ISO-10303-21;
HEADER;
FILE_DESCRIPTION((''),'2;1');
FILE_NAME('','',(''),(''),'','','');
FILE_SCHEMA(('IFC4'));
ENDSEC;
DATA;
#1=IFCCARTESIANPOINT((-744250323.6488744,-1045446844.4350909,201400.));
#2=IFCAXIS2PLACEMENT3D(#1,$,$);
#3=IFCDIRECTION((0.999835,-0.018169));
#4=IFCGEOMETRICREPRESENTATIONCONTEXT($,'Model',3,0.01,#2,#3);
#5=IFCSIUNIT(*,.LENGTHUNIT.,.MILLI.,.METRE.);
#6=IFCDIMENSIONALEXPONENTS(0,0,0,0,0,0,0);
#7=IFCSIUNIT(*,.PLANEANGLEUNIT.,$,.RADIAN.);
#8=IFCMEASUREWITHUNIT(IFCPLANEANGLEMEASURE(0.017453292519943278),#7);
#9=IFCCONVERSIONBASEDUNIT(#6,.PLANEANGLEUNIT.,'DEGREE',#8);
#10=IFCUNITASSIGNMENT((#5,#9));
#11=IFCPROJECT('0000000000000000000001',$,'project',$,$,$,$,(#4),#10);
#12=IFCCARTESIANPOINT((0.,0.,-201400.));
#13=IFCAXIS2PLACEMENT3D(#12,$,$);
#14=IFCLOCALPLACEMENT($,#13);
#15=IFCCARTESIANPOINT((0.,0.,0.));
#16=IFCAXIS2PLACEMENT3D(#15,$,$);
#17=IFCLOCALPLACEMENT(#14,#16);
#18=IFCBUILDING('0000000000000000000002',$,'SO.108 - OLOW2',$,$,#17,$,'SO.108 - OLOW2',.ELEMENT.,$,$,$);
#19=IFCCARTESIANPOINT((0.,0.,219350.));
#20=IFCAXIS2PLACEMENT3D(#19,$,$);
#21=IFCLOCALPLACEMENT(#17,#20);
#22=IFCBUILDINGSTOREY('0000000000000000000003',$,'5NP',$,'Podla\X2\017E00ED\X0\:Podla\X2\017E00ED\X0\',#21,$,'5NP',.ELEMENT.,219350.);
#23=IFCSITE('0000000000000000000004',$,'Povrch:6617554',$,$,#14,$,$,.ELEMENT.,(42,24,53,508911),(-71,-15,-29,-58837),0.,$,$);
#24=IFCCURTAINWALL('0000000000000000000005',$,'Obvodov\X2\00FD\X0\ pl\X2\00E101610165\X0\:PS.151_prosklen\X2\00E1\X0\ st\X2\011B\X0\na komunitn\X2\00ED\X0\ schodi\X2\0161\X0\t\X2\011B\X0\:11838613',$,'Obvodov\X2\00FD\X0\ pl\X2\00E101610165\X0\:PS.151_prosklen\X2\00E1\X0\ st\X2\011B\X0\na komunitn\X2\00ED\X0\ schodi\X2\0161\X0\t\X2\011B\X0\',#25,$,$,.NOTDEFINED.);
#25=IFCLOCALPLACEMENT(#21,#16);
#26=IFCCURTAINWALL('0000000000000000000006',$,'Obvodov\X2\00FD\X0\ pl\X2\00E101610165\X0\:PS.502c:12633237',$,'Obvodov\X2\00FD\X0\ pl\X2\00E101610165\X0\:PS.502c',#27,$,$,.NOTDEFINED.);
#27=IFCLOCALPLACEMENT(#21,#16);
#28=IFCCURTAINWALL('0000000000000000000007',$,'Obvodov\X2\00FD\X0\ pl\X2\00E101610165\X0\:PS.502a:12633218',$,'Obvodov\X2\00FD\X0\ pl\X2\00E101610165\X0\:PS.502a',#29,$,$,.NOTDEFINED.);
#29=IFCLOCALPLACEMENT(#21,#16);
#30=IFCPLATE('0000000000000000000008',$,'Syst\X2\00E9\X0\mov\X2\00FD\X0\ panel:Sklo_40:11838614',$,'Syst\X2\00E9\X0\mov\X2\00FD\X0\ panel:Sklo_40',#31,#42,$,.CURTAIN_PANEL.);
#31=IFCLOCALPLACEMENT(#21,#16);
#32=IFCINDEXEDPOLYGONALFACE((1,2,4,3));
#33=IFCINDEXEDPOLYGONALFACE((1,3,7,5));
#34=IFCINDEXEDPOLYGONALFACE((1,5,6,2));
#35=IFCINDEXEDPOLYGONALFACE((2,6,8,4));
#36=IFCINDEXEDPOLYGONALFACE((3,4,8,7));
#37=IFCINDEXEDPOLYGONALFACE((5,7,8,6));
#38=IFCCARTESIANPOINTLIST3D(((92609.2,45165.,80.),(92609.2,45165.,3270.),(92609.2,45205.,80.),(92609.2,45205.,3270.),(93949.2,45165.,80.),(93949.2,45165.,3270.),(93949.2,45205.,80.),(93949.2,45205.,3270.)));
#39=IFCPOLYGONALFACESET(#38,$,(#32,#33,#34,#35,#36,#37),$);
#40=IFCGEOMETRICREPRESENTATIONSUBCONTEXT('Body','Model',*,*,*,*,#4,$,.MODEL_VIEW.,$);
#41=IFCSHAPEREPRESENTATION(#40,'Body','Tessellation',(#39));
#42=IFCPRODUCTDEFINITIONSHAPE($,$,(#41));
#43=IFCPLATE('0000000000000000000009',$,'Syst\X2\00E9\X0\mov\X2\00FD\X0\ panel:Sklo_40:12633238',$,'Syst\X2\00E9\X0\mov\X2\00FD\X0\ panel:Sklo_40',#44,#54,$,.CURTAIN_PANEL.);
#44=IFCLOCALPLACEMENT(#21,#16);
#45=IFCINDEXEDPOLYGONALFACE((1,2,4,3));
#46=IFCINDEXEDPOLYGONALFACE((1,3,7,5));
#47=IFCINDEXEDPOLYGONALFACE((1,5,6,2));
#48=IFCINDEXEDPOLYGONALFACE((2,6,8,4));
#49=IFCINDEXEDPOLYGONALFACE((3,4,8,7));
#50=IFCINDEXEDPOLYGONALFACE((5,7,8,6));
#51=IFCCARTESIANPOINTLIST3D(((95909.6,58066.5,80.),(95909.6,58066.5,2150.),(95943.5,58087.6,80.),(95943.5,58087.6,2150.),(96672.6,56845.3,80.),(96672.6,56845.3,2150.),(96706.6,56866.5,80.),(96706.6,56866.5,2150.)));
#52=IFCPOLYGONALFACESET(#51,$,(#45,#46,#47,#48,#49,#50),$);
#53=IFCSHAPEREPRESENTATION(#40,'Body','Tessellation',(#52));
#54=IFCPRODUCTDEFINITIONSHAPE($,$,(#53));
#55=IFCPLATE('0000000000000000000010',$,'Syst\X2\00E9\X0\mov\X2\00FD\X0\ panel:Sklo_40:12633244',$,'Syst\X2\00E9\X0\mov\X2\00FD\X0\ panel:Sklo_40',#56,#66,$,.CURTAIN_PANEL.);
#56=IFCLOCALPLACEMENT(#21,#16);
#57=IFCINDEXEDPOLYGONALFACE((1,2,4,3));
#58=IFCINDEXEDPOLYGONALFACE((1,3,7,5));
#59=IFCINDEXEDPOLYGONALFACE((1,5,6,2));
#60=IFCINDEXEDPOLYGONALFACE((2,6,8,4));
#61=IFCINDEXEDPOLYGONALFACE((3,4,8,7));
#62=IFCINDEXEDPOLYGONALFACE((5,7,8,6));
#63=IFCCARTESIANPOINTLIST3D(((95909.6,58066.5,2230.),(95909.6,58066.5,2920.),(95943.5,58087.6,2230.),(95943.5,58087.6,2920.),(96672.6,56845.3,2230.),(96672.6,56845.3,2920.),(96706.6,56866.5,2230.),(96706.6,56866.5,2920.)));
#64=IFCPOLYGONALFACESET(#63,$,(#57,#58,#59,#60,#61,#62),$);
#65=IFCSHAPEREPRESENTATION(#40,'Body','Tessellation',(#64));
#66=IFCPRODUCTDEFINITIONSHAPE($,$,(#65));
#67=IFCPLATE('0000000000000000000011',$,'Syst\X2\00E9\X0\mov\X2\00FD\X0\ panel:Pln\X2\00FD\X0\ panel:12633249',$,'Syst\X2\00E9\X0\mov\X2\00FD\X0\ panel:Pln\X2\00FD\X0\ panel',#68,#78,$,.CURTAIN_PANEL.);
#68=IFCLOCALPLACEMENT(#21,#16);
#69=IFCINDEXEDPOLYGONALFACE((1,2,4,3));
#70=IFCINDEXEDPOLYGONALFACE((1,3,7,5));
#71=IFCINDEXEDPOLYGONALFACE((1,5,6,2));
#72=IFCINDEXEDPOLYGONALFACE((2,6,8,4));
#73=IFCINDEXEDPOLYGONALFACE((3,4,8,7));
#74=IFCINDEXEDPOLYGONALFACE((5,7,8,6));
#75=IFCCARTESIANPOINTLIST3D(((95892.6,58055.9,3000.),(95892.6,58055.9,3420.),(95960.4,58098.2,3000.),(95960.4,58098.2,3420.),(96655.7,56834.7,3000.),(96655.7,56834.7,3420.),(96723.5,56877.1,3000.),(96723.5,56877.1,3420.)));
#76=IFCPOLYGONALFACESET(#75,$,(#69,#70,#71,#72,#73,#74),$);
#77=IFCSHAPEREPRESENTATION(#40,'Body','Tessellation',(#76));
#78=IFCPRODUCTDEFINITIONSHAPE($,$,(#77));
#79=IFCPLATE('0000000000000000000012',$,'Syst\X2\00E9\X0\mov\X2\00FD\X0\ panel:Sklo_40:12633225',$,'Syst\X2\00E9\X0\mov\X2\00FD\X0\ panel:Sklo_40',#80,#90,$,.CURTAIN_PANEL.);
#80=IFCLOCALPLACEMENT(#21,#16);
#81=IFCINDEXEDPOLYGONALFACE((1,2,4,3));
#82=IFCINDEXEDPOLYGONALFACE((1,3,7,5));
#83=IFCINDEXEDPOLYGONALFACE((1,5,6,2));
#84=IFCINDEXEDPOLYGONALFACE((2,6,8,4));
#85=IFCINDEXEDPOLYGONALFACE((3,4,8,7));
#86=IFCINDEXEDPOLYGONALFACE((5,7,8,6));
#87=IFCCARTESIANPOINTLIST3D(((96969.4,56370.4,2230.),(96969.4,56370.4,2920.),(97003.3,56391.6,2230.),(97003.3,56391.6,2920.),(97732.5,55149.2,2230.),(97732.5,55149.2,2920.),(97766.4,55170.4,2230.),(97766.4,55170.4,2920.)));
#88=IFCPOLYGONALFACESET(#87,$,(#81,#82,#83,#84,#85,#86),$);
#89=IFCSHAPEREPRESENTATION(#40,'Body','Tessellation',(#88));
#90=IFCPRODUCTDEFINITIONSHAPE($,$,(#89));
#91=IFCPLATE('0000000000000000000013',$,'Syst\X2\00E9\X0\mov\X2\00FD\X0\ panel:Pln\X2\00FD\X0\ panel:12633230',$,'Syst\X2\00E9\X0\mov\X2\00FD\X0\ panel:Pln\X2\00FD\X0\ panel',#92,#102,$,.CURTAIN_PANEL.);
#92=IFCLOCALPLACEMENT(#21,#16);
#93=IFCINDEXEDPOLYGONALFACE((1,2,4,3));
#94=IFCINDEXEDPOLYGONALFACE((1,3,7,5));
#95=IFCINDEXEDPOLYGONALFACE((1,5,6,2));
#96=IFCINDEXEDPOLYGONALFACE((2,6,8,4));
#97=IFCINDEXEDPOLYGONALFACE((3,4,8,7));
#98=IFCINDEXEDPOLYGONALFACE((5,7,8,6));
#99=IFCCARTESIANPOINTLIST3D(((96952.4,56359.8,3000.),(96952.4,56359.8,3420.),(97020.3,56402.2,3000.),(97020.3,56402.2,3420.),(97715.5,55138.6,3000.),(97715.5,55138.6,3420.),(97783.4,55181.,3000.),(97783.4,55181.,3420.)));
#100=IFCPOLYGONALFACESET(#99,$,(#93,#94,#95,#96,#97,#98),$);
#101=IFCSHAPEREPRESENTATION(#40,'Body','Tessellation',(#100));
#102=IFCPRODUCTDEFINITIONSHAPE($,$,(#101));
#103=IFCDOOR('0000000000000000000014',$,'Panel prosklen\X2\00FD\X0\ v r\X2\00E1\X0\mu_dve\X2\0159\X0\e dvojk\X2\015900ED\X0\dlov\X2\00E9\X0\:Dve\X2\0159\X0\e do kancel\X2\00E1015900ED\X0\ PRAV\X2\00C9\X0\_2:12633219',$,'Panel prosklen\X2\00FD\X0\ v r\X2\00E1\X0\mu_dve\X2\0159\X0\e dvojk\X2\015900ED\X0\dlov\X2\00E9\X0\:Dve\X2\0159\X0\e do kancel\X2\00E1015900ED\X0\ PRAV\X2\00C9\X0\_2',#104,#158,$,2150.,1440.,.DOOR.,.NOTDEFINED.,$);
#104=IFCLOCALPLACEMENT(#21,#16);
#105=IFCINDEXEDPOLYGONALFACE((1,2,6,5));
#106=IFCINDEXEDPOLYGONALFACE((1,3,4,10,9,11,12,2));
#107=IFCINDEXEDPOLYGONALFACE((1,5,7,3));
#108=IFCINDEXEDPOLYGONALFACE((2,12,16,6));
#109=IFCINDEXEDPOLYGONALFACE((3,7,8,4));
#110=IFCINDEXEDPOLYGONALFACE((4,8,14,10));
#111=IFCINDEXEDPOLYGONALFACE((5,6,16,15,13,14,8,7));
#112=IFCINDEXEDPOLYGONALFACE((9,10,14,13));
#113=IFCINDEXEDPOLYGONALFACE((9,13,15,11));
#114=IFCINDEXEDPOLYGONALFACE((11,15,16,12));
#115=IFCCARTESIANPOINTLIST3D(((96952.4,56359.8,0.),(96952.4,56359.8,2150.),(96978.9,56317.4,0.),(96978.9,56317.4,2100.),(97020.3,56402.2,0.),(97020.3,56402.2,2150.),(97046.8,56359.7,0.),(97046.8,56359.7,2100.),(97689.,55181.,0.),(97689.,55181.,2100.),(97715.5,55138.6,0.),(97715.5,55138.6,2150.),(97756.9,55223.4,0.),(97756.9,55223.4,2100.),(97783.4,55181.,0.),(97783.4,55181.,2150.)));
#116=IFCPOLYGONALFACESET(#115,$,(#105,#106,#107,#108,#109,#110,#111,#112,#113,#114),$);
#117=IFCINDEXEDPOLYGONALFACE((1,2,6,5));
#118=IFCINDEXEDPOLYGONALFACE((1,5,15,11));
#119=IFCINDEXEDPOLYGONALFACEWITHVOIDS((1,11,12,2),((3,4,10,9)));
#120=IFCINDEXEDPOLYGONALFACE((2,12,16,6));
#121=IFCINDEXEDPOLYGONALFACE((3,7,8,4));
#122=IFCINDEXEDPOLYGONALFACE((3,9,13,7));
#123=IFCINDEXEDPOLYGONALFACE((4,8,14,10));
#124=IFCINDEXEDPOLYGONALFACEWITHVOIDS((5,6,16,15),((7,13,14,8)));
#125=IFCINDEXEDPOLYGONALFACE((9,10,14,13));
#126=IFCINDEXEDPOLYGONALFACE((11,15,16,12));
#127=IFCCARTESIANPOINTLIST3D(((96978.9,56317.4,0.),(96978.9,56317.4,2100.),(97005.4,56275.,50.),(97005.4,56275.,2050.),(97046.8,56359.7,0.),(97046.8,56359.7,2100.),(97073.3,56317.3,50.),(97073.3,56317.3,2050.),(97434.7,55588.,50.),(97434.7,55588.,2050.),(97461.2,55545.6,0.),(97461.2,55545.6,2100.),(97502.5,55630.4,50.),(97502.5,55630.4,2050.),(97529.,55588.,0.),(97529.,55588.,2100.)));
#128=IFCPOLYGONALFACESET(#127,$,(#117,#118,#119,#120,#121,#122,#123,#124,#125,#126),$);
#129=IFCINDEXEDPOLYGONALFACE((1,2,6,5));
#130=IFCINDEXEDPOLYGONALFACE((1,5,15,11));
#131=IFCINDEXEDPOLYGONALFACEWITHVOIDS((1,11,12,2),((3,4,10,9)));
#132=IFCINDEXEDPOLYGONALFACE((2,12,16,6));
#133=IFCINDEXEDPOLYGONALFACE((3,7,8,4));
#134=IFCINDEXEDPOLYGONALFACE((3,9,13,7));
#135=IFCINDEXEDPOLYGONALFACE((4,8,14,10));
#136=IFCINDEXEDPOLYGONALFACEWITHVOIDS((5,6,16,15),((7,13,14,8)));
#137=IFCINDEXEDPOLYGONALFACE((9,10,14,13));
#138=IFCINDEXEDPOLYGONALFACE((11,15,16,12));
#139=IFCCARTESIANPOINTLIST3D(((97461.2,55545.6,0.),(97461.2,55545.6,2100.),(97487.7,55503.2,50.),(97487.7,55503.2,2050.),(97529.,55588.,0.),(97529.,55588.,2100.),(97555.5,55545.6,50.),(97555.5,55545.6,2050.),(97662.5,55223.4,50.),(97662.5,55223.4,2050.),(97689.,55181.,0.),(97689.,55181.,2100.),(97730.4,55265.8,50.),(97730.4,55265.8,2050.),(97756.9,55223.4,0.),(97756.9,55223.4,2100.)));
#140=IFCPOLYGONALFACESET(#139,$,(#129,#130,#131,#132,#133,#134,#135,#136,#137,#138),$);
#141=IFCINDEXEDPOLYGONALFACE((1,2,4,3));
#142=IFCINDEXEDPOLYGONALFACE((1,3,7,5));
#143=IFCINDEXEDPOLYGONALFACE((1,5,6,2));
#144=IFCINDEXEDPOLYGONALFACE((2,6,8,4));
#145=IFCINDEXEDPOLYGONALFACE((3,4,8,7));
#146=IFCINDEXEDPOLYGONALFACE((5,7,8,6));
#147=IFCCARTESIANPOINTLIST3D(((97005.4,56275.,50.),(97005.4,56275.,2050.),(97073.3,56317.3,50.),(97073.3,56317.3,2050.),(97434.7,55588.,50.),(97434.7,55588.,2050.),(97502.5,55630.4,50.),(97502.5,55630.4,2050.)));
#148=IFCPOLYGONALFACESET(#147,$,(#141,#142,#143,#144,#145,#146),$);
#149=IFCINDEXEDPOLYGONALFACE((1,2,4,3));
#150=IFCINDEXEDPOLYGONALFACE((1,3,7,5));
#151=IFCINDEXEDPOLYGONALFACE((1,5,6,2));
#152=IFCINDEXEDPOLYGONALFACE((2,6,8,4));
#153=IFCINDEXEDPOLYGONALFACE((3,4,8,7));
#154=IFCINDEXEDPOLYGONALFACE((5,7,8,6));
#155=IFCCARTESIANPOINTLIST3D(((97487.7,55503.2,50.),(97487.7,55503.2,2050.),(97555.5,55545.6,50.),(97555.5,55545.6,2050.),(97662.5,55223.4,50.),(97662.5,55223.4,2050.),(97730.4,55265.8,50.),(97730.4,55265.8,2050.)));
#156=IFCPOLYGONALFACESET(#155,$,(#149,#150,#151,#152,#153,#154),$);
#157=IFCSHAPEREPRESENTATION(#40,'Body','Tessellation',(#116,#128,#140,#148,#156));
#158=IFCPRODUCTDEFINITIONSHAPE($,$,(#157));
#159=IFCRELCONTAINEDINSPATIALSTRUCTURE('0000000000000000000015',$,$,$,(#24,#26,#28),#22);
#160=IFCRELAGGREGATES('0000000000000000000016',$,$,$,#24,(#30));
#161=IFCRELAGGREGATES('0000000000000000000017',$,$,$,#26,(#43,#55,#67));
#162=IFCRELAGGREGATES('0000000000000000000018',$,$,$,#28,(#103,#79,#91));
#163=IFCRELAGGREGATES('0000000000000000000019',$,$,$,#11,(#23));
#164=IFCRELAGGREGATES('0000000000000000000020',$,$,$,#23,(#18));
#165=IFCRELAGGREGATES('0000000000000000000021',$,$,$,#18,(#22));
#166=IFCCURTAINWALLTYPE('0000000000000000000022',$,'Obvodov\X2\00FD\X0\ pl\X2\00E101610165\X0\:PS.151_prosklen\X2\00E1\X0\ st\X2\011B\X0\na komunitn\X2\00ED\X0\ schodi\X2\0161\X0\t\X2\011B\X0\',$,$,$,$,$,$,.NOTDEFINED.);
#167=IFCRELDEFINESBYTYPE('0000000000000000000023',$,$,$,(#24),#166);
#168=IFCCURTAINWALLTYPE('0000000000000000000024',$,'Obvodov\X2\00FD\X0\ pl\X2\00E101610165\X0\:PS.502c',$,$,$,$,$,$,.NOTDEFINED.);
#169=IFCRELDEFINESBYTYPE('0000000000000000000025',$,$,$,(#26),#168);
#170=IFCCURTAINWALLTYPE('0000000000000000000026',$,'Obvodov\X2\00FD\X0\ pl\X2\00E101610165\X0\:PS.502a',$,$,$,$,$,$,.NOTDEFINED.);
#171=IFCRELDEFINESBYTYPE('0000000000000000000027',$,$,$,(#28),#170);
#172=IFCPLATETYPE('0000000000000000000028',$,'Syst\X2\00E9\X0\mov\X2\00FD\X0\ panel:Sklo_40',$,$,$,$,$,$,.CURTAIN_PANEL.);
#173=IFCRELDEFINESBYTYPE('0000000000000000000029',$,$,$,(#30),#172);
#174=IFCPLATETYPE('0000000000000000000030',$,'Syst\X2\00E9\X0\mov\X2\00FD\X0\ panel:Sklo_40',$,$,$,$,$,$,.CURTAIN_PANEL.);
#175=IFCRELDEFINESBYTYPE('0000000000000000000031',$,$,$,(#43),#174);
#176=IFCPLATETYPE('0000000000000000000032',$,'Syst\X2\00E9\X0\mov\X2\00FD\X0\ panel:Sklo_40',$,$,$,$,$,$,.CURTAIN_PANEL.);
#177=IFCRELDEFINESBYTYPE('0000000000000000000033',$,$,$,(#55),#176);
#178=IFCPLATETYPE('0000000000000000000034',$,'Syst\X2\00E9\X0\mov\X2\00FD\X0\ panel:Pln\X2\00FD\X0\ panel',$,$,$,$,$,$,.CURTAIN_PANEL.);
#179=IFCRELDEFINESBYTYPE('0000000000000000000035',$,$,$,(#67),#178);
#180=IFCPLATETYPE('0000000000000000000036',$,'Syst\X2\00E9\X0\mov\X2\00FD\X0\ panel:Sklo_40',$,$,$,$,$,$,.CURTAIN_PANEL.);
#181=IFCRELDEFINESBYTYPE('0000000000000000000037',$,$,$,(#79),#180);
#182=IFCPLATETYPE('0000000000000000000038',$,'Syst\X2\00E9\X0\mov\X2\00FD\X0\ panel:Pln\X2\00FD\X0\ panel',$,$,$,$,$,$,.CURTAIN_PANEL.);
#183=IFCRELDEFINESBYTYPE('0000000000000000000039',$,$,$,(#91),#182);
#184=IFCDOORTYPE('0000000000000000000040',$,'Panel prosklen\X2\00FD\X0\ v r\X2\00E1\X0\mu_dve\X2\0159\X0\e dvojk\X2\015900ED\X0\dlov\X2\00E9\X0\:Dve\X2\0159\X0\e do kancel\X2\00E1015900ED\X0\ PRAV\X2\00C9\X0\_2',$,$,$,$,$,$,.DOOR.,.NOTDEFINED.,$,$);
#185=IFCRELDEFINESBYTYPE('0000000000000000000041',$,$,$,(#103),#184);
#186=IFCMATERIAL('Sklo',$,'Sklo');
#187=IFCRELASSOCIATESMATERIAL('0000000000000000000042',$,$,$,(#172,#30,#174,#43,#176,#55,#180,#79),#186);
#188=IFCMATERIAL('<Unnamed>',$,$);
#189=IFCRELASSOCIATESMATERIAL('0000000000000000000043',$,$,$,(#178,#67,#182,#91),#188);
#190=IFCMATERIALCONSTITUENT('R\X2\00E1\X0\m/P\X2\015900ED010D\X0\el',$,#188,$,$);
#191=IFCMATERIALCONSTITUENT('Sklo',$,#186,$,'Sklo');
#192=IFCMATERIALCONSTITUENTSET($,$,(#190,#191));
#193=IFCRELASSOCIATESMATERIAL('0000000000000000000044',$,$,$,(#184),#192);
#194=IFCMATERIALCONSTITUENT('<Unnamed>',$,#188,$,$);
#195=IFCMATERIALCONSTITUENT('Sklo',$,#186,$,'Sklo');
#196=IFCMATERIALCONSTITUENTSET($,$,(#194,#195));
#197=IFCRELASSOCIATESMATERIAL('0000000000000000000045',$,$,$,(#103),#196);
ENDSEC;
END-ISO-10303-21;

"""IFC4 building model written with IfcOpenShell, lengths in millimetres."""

from ifc_helpers import new_model, entity, si_unit, converted_unit, direction, frame, origin, place, context, subcontext, project, spatial, indexed_curve, outline, extrude, source, transform, mapped, material, constituent, constituent_set, type_object, type_shapes, element, aggregate, save


model = new_model("IFC4")

# Units and contexts
model_context = context("Model", 3, precision=0.01, world=frame((-744250323.6488744, -1045446844.4350909, 201400.0)), true_north=direction((0.999835, -0.018169)))
body_context = subcontext(model_context, "Body", "Model", "MODEL_VIEW")
ifc_project = project(units=[si_unit("LENGTHUNIT", "METRE", prefix="MILLI"), converted_unit("PLANEANGLEUNIT", "DEGREE", entity("IfcPlaneAngleMeasure", 0.017453292519943278), si_unit("PLANEANGLEUNIT", "RADIAN"), dimensions=[0, 0, 0, 0, 0, 0, 0])], contexts=[model_context])

# Site, building, storey
site_placement = place(None, frame((0.0, 0.0, -201400.0)))
site = spatial("IfcSite", under=ifc_project, at=site_placement, Name="Povrch:6617554", CompositionType="ELEMENT", RefLatitude=(42, 24, 53, 508911), RefLongitude=(-71, -15, -29, -58837), RefElevation=0.0)
building_placement = place(site_placement, origin())
building = spatial("IfcBuilding", under=site, at=building_placement, Name="SO.108 - OLOW2", LongName="SO.108 - OLOW2", CompositionType="ELEMENT")
storey_placement = place(building_placement, frame((0.0, 0.0, 219350.0)))
storey = spatial("IfcBuildingStorey", under=building, at=storey_placement, Name="5NP", ObjectType="Podlaží:Podlaží", LongName="5NP", CompositionType="ELEMENT", Elevation=219350.0)

# Curtain wall
curtain_wall_type_1 = type_object("IfcCurtainWallType", Name="Obvodový plášť:PS.151_prosklená stěna komunitní schodiště", PredefinedType="NOTDEFINED")
curtain_wall_1_placement = place(storey_placement, frame((0.0, 0.0, -219350.0)))
curtain_wall_1 = element("IfcCurtainWall", 1, at=curtain_wall_1_placement, inside=storey, type_object=curtain_wall_type_1, Name="Obvodový plášť:PS.151_prosklená stěna komunitní schodiště:11838613", ObjectType="Obvodový plášť:PS.151_prosklená stěna komunitní schodiště", PredefinedType="NOTDEFINED")
ifc_material_1 = material(Name="<Unnamed>")

# Curtain wall
curtain_wall_type_2 = type_object("IfcCurtainWallType", Name="Obvodový plášť:PS.502c", PredefinedType="NOTDEFINED")
curtain_wall_2_placement = place(storey_placement, frame((0.0, 0.0, -219350.0)))
curtain_wall_2 = element("IfcCurtainWall", 2, at=curtain_wall_2_placement, inside=storey, type_object=curtain_wall_type_2, Name="Obvodový plášť:PS.502c:12633237", ObjectType="Obvodový plášť:PS.502c", PredefinedType="NOTDEFINED")

# Curtain wall
curtain_wall_type_3 = type_object("IfcCurtainWallType", Name="Obvodový plášť:PS.502a", PredefinedType="NOTDEFINED")
curtain_wall_3_placement = place(storey_placement, frame((0.0, 0.0, -219350.0)))
curtain_wall_3 = element("IfcCurtainWall", 3, at=curtain_wall_3_placement, inside=storey, type_object=curtain_wall_type_3, Name="Obvodový plášť:PS.502a:12633218", ObjectType="Obvodový plášť:PS.502a", PredefinedType="NOTDEFINED")

# Plates
ifc_material_2 = material(Name="Sklo", Category="Sklo")
plate_type_1 = type_object("IfcPlateType", Name="Systémový panel:Sklo_40", PredefinedType="CURTAIN_PANEL", material=ifc_material_2)
shared_shape_1 = source(origin(), body_context, "Body", "SweptSolid", [
    extrude(outline(indexed_curve([(-20.0, -670.0), (20.0, -670.0), (20.0, 670.0), (-20.0, 670.0), (-20.0, -670.0)], self_intersect=False)), frame((0.0, 0.0, 0.0), z_axis=(0.0, 0.0, 1.0), x_axis=(0.0, 1.0, 0.0)), (0.0, 0.0, 1.0), 3190.0),
])
type_shapes(plate_type_1, [shared_shape_1])
plate_1_placement = place(curtain_wall_1_placement, frame((93279.2, 45185.0, 219430.0)))
plate_1 = element("IfcPlate", 4, at=plate_1_placement, type_object=plate_type_1, material=ifc_material_2, Name="Systémový panel:Sklo_40:11838614", ObjectType="Systémový panel:Sklo_40", PredefinedType="CURTAIN_PANEL", context=body_context, shape_type="MappedRepresentation", body=[
    mapped(shared_shape_1, transform((0.0, 0.0, 0.0), scale=1.0)),
])
aggregate(curtain_wall_1, [plate_1])
plate_type_2 = type_object("IfcPlateType", Name="Systémový panel:Sklo_40", PredefinedType="CURTAIN_PANEL", material=ifc_material_2)
shared_shape_2 = source(origin(), body_context, "Body", "SweptSolid", [
    extrude(outline(indexed_curve([(-20.0, -720.0), (20.0, -720.0), (20.0, 720.0), (-20.0, 720.0), (-20.0, -720.0)], self_intersect=False)), frame((0.0, 0.0, 0.0), z_axis=(0.0, 0.0, 1.0), x_axis=(0.0, 1.0, 0.0)), (0.0, 0.0, 1.0), 2070.0),
])
type_shapes(plate_type_2, [shared_shape_2])
plate_2_placement = place(curtain_wall_2_placement, frame((96308.1, 57466.5, 219430.0), z_axis=(0.0, 0.0, 1.0), x_axis=(-0.529919, 0.848048, 0.0)))
plate_2 = element("IfcPlate", 5, at=plate_2_placement, type_object=plate_type_2, material=ifc_material_2, Name="Systémový panel:Sklo_40:12633238", ObjectType="Systémový panel:Sklo_40", PredefinedType="CURTAIN_PANEL", context=body_context, shape_type="MappedRepresentation", body=[
    mapped(shared_shape_2, transform((0.0, 0.0, 0.0), scale=1.0)),
])
plate_type_3 = type_object("IfcPlateType", Name="Systémový panel:Sklo_40", PredefinedType="CURTAIN_PANEL", material=ifc_material_2)
shared_shape_3 = source(origin(), body_context, "Body", "SweptSolid", [
    extrude(outline(indexed_curve([(-20.0, -720.0), (20.0, -720.0), (20.0, 720.0), (-20.0, 720.0), (-20.0, -720.0)], self_intersect=False)), frame((0.0, 0.0, 0.0), z_axis=(0.0, 0.0, 1.0), x_axis=(0.0, 1.0, 0.0)), (0.0, 0.0, 1.0), 690.0),
])
type_shapes(plate_type_3, [shared_shape_3])
plate_3_placement = place(curtain_wall_2_placement, frame((96308.1, 57466.5, 221580.0), z_axis=(0.0, 0.0, 1.0), x_axis=(-0.529919, 0.848048, 0.0)))
plate_3 = element("IfcPlate", 6, at=plate_3_placement, type_object=plate_type_3, material=ifc_material_2, Name="Systémový panel:Sklo_40:12633244", ObjectType="Systémový panel:Sklo_40", PredefinedType="CURTAIN_PANEL", context=body_context, shape_type="MappedRepresentation", body=[
    mapped(shared_shape_3, transform((0.0, 0.0, 0.0), scale=1.0)),
])
plate_type_4 = type_object("IfcPlateType", Name="Systémový panel:Plný panel", PredefinedType="CURTAIN_PANEL", material=ifc_material_1)
shared_shape_4 = source(origin(), body_context, "Body", "SweptSolid", [
    extrude(outline(indexed_curve([(-40.0, -720.0), (40.0, -720.0), (40.0, 720.0), (-40.0, 720.0), (-40.0, -720.0)], self_intersect=False)), frame((0.0, 0.0, 0.0), z_axis=(0.0, 0.0, 1.0), x_axis=(0.0, 1.0, 0.0)), (0.0, 0.0, 1.0), 420.0),
])
type_shapes(plate_type_4, [shared_shape_4])
plate_4_placement = place(curtain_wall_2_placement, frame((96308.1, 57466.5, 222350.0), z_axis=(0.0, 0.0, 1.0), x_axis=(-0.529919, 0.848048, 0.0)))
plate_4 = element("IfcPlate", 7, at=plate_4_placement, type_object=plate_type_4, material=ifc_material_1, Name="Systémový panel:Plný panel:12633249", ObjectType="Systémový panel:Plný panel", PredefinedType="CURTAIN_PANEL", context=body_context, shape_type="MappedRepresentation", body=[
    mapped(shared_shape_4, transform((0.0, 0.0, 0.0), scale=1.0)),
])
aggregate(curtain_wall_2, [plate_2, plate_3, plate_4])
plate_type_5 = type_object("IfcPlateType", Name="Systémový panel:Sklo_40", PredefinedType="CURTAIN_PANEL", material=ifc_material_2)
shared_shape_5 = source(origin(), body_context, "Body", "SweptSolid", [
    extrude(outline(indexed_curve([(-20.0, -720.0), (20.0, -720.0), (20.0, 720.0), (-20.0, 720.0), (-20.0, -720.0)], self_intersect=False)), frame((0.0, 0.0, 0.0), z_axis=(0.0, 0.0, 1.0), x_axis=(0.0, 1.0, 0.0)), (0.0, 0.0, 1.0), 690.0),
])
type_shapes(plate_type_5, [shared_shape_5])
plate_5_placement = place(curtain_wall_3_placement, frame((97367.9, 55770.4, 221580.0), z_axis=(0.0, 0.0, 1.0), x_axis=(-0.529919, 0.848048, 0.0)))
plate_5 = element("IfcPlate", 8, at=plate_5_placement, type_object=plate_type_5, material=ifc_material_2, Name="Systémový panel:Sklo_40:12633225", ObjectType="Systémový panel:Sklo_40", PredefinedType="CURTAIN_PANEL", context=body_context, shape_type="MappedRepresentation", body=[
    mapped(shared_shape_5, transform((0.0, 0.0, 0.0), scale=1.0)),
])
plate_type_6 = type_object("IfcPlateType", Name="Systémový panel:Plný panel", PredefinedType="CURTAIN_PANEL", material=ifc_material_1)
shared_shape_6 = source(origin(), body_context, "Body", "SweptSolid", [
    extrude(outline(indexed_curve([(-40.0, -720.0), (40.0, -720.0), (40.0, 720.0), (-40.0, 720.0), (-40.0, -720.0)], self_intersect=False)), frame((0.0, 0.0, 0.0), z_axis=(0.0, 0.0, 1.0), x_axis=(0.0, 1.0, 0.0)), (0.0, 0.0, 1.0), 420.0),
])
type_shapes(plate_type_6, [shared_shape_6])
plate_6_placement = place(curtain_wall_3_placement, frame((97367.9, 55770.4, 222350.0), z_axis=(0.0, 0.0, 1.0), x_axis=(-0.529919, 0.848048, 0.0)))
plate_6 = element("IfcPlate", 9, at=plate_6_placement, type_object=plate_type_6, material=ifc_material_1, Name="Systémový panel:Plný panel:12633230", ObjectType="Systémový panel:Plný panel", PredefinedType="CURTAIN_PANEL", context=body_context, shape_type="MappedRepresentation", body=[
    mapped(shared_shape_6, transform((0.0, 0.0, 0.0), scale=1.0)),
])

# Door
ifc_constituent_1 = constituent(ifc_material_1, Name="<Unnamed>")
ifc_constituent_2 = constituent(ifc_material_2, Name="Sklo", Category="Sklo")
ifc_constituent_set_1 = constituent_set(constituents=[ifc_constituent_1, ifc_constituent_2])
ifc_constituent_3 = constituent(ifc_material_1, Name="Rám/Příčel")
ifc_constituent_4 = constituent(ifc_material_2, Name="Sklo", Category="Sklo")
ifc_constituent_set_2 = constituent_set(constituents=[ifc_constituent_3, ifc_constituent_4])
door_type = type_object("IfcDoorType", Name="Panel prosklený v rámu_dveře dvojkřídlové:Dveře do kanceláří PRAVÉ_2", OperationType="NOTDEFINED", PredefinedType="DOOR", material=ifc_constituent_set_2)
shared_shape_7 = source(origin(), body_context, "Body", "SweptSolid", [
    extrude(outline(indexed_curve([(-720.0, -1087.5), (720.0, -1087.5), (720.0, 1062.5), (670.0, 1062.5), (670.0, -1037.5), (-670.0, -1037.5), (-670.0, 1062.5), (-720.0, 1062.5), (-720.0, -1087.5)], self_intersect=False)), frame((0.0, -40.0, 1062.5), z_axis=(0.0, 1.0, 0.0), x_axis=(1.0, 0.0, 0.0)), (0.0, 0.0, 1.0), 80.0),
    extrude(outline(indexed_curve([(-1050.0, -455.0), (1050.0, -455.0), (1050.0, 455.0), (-1050.0, 455.0), (-1050.0, -455.0)], self_intersect=False), holes=[indexed_curve([(-1000.0, -405.0), (-1000.0, 405.0), (1000.0, 405.0), (1000.0, -405.0), (-1000.0, -405.0)], self_intersect=False)]), frame((215.0, -40.0, 1050.0), z_axis=(0.0, 1.0, 0.0), x_axis=(0.0, 0.0, -1.0)), (0.0, 0.0, 1.0), 80.0),
    extrude(outline(indexed_curve([(-1050.0, -215.0), (1050.0, -215.0), (1050.0, 215.0), (-1050.0, 215.0), (-1050.0, -215.0)], self_intersect=False), holes=[indexed_curve([(-1000.0, -165.0), (-1000.0, 165.0), (1000.0, 165.0), (1000.0, -165.0), (-1000.0, -165.0)], self_intersect=False)]), frame((-455.0, -40.0, 1050.0), z_axis=(0.0, 1.0, 0.0), x_axis=(0.0, 0.0, -1.0)), (0.0, 0.0, 1.0), 80.0),
    extrude(outline(indexed_curve([(-40.0, -405.0), (40.0, -405.0), (40.0, 405.0), (-40.0, 405.0), (-40.0, -405.0)], self_intersect=False)), frame((215.0, 0.0, 50.0), z_axis=(0.0, 0.0, 1.0), x_axis=(0.0, 1.0, 0.0)), (0.0, 0.0, 1.0), 2000.0),
    extrude(outline(indexed_curve([(-40.0, -165.0), (40.0, -165.0), (40.0, 165.0), (-40.0, 165.0), (-40.0, -165.0)], self_intersect=False)), frame((-455.0, 0.0, 50.0), z_axis=(0.0, 0.0, 1.0), x_axis=(0.0, 1.0, 0.0)), (0.0, 0.0, 1.0), 2000.0),
])
type_shapes(door_type, [shared_shape_7])
door_placement = place(curtain_wall_3_placement, frame((97367.9, 55770.4, 219350.0), z_axis=(0.0, 0.0, 1.0), x_axis=(-0.529919, 0.848048, 0.0)))
door = element("IfcDoor", 10, at=door_placement, type_object=door_type, material=ifc_constituent_set_1, Name="Panel prosklený v rámu_dveře dvojkřídlové:Dveře do kanceláří PRAVÉ_2:12633219", ObjectType="Panel prosklený v rámu_dveře dvojkřídlové:Dveře do kanceláří PRAVÉ_2", OperationType="NOTDEFINED", OverallHeight=2150.0, OverallWidth=1440.0, PredefinedType="DOOR", context=body_context, shape_type="MappedRepresentation", body=[
    mapped(shared_shape_7, transform((0.0, 0.0, 0.0), scale=1.0)),
])
aggregate(curtain_wall_3, [door, plate_5, plate_6])

save(model, "model.ifc")
